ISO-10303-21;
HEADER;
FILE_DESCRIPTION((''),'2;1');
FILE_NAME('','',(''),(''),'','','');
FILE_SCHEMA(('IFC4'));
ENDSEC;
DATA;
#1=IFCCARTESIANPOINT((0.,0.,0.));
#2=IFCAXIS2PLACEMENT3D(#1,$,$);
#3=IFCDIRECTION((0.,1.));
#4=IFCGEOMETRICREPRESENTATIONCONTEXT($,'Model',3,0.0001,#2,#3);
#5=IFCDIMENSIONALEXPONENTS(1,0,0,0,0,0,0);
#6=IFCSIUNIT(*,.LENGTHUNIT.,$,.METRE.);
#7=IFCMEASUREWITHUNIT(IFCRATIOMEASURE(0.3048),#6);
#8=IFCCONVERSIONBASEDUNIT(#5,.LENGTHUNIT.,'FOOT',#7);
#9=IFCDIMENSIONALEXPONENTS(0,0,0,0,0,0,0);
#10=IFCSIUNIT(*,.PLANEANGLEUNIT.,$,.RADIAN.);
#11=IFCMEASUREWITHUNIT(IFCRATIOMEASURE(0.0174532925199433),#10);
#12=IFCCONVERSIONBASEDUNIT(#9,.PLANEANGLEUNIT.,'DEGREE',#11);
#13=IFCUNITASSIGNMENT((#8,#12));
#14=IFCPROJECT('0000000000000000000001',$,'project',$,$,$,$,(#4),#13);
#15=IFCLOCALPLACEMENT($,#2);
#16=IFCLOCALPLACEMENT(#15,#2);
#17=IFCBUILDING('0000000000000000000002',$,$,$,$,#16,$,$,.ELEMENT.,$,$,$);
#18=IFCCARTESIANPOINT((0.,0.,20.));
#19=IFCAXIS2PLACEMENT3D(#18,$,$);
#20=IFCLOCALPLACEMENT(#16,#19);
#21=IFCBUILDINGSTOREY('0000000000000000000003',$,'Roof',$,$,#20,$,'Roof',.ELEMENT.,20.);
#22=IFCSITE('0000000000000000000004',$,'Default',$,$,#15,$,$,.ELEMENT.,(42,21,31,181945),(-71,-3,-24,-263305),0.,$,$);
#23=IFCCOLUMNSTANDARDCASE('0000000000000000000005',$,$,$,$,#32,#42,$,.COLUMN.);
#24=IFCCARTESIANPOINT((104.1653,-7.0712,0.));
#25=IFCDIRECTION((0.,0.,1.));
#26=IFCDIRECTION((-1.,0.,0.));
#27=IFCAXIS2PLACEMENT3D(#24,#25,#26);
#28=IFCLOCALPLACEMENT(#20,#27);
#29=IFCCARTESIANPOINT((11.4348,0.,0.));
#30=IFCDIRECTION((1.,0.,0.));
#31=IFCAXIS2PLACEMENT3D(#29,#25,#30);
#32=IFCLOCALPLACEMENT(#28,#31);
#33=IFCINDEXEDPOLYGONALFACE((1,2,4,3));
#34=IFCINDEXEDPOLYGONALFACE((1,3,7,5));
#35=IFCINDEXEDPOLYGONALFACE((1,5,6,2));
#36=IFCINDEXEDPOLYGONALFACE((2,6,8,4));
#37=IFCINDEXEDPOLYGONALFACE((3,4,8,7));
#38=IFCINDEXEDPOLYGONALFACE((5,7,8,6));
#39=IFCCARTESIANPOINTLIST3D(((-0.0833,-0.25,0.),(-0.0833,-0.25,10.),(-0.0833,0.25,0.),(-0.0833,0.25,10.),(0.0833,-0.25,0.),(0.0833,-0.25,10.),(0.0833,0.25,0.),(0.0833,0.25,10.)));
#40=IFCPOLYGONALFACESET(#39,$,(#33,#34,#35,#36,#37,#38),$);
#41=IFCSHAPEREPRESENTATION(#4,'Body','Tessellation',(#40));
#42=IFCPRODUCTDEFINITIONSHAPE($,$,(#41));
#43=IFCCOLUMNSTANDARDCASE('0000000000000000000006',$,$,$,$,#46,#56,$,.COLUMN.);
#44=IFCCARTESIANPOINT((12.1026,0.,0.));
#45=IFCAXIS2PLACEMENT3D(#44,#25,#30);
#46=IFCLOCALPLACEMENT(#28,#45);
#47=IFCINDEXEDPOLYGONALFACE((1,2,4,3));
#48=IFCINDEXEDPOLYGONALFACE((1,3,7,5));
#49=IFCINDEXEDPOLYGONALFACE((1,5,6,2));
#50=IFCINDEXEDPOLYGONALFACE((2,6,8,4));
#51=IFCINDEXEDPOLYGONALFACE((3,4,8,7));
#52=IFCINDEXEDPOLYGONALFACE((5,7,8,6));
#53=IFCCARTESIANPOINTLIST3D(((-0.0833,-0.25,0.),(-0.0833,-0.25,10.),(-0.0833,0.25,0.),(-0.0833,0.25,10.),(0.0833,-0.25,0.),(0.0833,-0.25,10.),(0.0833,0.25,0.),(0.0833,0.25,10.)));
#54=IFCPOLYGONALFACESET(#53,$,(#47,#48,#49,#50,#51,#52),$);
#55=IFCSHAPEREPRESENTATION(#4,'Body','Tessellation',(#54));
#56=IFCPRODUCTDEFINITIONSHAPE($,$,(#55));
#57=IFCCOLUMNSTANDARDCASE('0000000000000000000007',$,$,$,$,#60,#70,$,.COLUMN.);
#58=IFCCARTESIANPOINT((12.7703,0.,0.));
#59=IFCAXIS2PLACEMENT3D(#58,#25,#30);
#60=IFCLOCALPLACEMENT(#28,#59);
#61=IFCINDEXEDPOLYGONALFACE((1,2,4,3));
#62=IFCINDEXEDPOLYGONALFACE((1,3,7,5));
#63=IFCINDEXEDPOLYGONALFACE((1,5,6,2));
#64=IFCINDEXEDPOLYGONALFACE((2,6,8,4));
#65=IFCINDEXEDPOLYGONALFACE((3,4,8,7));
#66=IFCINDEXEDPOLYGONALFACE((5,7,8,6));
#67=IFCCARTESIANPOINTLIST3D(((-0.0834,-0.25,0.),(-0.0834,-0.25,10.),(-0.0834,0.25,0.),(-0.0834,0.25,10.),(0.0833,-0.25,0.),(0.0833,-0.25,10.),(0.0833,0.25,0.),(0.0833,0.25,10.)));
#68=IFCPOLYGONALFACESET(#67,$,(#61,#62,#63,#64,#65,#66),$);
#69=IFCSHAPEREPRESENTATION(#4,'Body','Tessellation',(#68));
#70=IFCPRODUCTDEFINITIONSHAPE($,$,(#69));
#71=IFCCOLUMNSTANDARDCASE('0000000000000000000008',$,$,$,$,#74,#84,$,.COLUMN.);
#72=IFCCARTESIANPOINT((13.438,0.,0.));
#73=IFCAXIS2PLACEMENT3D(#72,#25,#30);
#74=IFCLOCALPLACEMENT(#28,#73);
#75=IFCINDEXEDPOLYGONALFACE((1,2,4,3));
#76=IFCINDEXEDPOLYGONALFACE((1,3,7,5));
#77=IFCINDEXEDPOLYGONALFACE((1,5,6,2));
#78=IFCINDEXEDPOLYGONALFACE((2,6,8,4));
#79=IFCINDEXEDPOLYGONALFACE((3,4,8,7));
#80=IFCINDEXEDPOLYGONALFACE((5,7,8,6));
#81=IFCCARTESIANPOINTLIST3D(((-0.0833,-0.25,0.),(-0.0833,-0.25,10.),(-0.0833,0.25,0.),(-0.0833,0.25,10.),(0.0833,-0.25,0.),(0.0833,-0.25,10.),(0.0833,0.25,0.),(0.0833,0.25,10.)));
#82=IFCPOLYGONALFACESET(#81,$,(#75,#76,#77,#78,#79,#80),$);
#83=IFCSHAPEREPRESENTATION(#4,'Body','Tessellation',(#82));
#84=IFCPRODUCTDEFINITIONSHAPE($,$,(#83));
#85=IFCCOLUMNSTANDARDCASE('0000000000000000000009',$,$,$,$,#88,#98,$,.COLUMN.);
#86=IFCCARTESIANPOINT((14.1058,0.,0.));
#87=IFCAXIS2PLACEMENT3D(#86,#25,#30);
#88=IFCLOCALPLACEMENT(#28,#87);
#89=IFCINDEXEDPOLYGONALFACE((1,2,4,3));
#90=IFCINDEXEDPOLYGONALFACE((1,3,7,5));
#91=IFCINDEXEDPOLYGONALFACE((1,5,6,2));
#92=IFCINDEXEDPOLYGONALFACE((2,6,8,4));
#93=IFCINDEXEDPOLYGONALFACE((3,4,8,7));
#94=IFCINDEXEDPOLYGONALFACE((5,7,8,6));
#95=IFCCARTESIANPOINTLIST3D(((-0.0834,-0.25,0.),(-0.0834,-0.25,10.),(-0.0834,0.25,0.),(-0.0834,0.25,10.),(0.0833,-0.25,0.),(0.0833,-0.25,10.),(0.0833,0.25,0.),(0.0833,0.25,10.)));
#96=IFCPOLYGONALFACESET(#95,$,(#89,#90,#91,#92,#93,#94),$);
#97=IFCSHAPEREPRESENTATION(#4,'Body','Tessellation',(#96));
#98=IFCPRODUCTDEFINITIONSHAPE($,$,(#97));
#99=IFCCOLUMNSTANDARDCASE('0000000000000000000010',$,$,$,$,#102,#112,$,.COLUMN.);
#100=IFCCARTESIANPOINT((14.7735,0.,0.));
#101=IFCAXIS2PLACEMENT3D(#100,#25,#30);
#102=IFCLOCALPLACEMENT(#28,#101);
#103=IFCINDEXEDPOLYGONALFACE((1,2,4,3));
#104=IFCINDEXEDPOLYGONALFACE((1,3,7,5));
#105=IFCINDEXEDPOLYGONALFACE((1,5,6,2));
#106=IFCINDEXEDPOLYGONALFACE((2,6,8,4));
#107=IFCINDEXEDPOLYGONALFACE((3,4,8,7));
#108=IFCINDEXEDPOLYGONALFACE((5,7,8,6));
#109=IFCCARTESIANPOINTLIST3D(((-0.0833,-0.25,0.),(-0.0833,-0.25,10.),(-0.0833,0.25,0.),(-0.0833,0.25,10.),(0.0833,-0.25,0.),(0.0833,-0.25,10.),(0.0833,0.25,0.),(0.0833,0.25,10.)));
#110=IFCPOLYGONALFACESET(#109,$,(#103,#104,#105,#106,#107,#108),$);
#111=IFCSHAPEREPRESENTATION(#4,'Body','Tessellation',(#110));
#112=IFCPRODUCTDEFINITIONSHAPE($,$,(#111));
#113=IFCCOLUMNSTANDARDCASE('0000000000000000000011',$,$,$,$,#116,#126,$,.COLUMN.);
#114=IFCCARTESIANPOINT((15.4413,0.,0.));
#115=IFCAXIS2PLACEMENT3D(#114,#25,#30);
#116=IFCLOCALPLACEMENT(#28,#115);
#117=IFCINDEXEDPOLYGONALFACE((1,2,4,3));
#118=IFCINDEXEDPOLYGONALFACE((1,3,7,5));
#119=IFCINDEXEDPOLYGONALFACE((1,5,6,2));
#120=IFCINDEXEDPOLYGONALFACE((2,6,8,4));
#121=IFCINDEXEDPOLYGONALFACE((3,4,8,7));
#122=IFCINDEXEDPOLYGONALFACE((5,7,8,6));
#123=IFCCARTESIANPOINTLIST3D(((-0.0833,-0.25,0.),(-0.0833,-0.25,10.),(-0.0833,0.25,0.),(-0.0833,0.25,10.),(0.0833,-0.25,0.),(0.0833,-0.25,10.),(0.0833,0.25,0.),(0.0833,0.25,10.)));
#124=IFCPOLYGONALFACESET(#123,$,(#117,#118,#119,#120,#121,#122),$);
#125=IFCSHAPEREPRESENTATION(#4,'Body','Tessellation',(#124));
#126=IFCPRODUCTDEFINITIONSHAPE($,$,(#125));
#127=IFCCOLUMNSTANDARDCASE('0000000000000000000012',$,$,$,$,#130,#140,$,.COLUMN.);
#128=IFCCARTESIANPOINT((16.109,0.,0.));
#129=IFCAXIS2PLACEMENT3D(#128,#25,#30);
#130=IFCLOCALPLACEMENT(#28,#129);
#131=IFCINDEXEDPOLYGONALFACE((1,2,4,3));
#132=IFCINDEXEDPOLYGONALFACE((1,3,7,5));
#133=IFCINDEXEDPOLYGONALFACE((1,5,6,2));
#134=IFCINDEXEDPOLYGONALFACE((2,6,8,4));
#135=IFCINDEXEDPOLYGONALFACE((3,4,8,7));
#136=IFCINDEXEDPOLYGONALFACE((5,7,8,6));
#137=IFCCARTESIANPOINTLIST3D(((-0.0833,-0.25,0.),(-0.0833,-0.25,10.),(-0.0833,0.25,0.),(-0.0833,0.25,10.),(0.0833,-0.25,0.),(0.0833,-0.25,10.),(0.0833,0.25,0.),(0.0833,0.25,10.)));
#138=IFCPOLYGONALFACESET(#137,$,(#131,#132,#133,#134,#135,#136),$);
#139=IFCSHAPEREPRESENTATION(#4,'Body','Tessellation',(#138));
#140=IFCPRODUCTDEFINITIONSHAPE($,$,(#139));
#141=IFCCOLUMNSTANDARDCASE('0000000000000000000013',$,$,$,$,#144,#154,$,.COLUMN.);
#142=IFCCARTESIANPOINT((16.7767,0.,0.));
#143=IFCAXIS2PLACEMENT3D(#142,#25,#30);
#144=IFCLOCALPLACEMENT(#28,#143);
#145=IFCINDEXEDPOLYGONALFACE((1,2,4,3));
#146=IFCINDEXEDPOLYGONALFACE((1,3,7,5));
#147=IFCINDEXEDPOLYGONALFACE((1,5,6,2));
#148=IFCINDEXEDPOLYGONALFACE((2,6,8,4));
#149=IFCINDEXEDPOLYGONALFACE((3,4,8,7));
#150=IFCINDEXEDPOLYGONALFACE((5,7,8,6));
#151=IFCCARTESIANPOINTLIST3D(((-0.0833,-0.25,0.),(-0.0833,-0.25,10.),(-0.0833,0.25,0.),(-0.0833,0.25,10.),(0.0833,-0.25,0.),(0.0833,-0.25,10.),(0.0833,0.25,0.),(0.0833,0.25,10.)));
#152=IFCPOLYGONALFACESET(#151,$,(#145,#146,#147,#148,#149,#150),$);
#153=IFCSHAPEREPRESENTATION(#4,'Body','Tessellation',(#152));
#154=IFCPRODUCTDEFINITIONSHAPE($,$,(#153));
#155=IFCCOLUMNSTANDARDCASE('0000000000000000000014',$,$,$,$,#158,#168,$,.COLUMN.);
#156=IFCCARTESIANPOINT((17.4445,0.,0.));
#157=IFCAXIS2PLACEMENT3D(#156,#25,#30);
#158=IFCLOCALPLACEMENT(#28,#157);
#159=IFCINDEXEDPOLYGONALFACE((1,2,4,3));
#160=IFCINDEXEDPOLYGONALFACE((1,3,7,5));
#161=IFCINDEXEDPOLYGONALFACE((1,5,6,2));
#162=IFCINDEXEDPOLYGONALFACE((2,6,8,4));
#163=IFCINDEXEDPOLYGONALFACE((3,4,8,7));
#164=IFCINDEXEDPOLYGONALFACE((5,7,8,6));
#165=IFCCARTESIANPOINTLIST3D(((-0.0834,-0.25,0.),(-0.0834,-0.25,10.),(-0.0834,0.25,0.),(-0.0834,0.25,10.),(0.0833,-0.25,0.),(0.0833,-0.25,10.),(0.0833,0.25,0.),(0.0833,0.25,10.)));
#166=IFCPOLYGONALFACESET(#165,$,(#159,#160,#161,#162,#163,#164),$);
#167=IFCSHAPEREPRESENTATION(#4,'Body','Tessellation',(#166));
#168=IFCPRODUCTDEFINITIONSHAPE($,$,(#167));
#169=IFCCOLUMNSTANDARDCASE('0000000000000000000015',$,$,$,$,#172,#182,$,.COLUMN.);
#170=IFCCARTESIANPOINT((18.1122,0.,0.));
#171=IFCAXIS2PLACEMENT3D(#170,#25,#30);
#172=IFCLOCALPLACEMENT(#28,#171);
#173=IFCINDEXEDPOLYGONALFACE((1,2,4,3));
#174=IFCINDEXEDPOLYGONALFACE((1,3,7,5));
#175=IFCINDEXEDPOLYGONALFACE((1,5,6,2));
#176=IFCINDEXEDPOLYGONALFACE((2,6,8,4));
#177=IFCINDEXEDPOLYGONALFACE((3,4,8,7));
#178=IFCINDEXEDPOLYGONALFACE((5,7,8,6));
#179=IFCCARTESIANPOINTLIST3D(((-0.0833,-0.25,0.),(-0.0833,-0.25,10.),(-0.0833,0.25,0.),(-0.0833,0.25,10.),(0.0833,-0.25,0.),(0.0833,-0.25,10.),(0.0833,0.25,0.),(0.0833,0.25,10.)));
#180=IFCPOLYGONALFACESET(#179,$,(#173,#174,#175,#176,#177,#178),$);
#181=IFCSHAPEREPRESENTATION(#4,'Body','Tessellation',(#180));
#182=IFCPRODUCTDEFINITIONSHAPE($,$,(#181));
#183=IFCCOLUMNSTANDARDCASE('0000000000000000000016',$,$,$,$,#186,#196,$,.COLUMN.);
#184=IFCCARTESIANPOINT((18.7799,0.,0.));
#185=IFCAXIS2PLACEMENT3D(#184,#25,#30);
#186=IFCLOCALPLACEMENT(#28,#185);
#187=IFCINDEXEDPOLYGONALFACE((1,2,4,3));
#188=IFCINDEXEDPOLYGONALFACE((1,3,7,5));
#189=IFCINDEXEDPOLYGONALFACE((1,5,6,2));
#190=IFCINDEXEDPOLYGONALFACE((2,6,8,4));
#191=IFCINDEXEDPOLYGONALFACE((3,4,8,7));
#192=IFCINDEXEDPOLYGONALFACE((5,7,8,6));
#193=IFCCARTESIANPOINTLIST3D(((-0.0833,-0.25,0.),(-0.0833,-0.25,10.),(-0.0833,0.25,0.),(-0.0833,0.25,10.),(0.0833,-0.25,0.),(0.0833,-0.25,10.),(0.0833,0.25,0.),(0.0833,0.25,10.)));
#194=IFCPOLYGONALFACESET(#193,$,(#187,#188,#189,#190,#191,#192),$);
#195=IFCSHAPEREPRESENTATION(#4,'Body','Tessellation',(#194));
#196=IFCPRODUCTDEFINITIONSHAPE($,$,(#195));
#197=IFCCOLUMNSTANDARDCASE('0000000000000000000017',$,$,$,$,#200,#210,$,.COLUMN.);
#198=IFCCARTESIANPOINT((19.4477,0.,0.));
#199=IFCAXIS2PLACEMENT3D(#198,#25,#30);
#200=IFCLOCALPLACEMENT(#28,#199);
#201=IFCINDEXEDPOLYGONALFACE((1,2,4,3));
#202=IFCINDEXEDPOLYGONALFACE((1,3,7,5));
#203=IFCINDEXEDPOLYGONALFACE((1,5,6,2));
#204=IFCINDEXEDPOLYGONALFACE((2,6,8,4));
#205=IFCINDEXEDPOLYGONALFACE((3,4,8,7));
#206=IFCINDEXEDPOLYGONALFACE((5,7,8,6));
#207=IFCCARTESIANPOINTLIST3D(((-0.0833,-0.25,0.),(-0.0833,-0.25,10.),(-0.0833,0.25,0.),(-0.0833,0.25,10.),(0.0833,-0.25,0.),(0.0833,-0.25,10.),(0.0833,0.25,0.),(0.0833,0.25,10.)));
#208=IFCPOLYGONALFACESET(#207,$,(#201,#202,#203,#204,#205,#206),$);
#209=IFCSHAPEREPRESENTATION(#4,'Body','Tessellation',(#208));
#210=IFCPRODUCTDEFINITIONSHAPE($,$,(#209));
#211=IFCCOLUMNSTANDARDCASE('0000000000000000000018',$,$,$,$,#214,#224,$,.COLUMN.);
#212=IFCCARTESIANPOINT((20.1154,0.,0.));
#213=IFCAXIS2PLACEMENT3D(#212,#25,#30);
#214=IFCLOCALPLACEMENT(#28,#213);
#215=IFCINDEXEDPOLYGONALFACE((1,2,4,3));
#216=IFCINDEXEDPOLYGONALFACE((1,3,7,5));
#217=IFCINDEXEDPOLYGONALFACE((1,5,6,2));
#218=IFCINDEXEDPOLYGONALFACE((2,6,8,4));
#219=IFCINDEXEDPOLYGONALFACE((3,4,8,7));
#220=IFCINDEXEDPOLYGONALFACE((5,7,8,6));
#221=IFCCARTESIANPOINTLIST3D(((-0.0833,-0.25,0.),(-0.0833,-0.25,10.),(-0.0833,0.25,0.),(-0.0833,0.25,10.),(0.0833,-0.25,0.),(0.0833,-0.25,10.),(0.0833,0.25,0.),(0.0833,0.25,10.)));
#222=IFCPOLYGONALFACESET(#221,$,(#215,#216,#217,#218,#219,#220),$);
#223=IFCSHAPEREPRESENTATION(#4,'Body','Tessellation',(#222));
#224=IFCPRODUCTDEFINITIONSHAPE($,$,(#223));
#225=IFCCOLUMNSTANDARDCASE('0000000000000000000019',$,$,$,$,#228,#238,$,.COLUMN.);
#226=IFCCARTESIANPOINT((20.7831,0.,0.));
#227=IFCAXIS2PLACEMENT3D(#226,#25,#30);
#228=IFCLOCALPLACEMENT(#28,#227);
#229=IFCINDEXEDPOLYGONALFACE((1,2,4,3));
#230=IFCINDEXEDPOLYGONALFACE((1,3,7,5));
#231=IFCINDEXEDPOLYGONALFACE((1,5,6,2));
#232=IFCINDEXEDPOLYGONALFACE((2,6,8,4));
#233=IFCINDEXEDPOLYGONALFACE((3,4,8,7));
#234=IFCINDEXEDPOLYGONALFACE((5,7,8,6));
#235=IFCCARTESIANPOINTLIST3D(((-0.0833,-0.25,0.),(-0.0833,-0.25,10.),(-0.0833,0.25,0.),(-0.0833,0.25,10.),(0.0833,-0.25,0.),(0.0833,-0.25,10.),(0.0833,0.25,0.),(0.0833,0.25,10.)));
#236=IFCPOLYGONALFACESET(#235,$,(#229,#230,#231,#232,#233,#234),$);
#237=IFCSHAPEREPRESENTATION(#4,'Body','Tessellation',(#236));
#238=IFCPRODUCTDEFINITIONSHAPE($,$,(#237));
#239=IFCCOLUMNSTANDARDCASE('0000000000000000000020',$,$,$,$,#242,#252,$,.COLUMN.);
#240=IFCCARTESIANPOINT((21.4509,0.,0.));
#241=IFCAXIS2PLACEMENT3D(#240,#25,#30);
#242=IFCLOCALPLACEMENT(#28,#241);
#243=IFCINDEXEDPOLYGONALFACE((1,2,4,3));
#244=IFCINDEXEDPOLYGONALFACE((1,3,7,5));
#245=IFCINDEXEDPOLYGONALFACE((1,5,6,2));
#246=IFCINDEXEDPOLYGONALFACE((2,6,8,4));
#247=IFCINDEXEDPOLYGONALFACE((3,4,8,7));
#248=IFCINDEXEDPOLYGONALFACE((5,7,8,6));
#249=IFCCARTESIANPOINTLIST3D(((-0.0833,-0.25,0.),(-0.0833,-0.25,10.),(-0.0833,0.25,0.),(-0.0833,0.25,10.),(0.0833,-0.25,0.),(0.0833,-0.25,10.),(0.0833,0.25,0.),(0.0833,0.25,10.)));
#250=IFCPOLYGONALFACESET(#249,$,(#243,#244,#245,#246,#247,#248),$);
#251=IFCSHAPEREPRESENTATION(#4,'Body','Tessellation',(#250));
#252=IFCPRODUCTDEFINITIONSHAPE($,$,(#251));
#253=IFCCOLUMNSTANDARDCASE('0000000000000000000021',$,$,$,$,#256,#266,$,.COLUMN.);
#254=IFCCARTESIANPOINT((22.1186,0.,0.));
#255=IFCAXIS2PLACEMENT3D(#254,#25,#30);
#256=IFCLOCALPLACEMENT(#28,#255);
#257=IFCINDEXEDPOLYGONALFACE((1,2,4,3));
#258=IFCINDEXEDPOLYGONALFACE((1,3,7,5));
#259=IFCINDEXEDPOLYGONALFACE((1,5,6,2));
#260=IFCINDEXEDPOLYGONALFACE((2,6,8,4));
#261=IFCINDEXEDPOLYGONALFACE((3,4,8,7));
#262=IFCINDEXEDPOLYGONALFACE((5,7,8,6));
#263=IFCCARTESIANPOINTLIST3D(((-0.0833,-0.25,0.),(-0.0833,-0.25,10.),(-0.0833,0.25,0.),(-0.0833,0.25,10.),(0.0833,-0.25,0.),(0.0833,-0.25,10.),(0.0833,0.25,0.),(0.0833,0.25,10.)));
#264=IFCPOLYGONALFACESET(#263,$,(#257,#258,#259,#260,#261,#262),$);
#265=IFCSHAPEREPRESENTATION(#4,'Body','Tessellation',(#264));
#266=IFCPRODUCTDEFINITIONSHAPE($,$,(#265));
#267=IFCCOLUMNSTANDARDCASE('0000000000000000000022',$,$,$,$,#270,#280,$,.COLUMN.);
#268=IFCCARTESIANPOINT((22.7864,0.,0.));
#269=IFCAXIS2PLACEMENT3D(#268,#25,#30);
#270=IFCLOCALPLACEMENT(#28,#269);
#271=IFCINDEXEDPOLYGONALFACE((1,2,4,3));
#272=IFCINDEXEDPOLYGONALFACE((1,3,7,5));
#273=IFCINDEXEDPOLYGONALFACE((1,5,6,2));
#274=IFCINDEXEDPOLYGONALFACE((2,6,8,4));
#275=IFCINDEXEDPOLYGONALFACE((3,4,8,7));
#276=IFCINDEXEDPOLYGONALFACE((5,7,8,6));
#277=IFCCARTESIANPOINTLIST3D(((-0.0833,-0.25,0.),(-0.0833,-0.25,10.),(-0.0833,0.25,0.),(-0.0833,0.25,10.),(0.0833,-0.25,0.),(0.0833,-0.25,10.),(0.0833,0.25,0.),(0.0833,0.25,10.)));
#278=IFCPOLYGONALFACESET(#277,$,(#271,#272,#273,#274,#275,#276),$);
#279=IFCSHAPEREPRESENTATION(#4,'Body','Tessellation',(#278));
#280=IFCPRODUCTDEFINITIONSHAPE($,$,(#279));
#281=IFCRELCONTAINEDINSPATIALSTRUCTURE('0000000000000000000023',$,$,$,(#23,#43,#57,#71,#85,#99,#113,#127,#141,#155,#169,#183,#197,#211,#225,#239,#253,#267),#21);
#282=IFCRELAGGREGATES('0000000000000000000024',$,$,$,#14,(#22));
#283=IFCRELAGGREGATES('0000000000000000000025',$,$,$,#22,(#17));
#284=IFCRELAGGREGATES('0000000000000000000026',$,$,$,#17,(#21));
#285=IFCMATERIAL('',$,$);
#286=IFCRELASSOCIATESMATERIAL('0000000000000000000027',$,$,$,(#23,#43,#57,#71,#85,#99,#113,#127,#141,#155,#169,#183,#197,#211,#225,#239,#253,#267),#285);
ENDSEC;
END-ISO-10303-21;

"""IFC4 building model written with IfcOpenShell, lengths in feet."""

from ifc_helpers import new_model, entity, si_unit, converted_unit, direction, frame, origin, place, context, project, spatial, rectangle, extrude, material, element, save


model = new_model("IFC4")

# Units and contexts
model_context = context("Model", 3, precision=0.0001, world=origin(), true_north=direction((0.0, 1.0)))
ifc_project = project(units=[converted_unit("LENGTHUNIT", "FOOT", entity("IfcRatioMeasure", 0.3048), si_unit("LENGTHUNIT", "METRE"), dimensions=[1, 0, 0, 0, 0, 0, 0]), converted_unit("PLANEANGLEUNIT", "DEGREE", entity("IfcRatioMeasure", 0.0174532925199433), si_unit("PLANEANGLEUNIT", "RADIAN"), dimensions=[0, 0, 0, 0, 0, 0, 0])], contexts=[model_context])

# Site, building, storey
site_placement = place(None, origin())
site = spatial("IfcSite", under=ifc_project, at=site_placement, Name="Default", CompositionType="ELEMENT", RefLatitude=(42, 21, 31, 181945), RefLongitude=(-71, -3, -24, -263305), RefElevation=0.0)
building_placement = place(site_placement, origin())
building = spatial("IfcBuilding", under=site, at=building_placement, CompositionType="ELEMENT")
storey_placement = place(building_placement, frame((0.0, 0.0, 20.0)))
storey = spatial("IfcBuildingStorey", under=building, at=storey_placement, Name="Roof", LongName="Roof", CompositionType="ELEMENT", Elevation=20.0)

# Columns
ifc_material_1 = material(Name="")
placement_1 = place(storey_placement, frame((104.1653, -7.0712, 0.0), z_axis=(0.0, 0.0, 1.0), x_axis=(-1.0, 0.0, 0.0)))
for number, where, z_axis, x_axis in (
    (1, (11.4348, 0.0, 0.0), (0.0, 0.0, 1.0), (1.0, 0.0, 0.0)),
    (2, (12.1026, 0.0, 0.0), (0.0, 0.0, 1.0), (1.0, 0.0, 0.0)),
    (3, (12.7703, 0.0, 0.0), (0.0, 0.0, 1.0), (1.0, 0.0, 0.0)),
    (4, (13.438, 0.0, 0.0), (0.0, 0.0, 1.0), (1.0, 0.0, 0.0)),
    (5, (14.1058, 0.0, 0.0), (0.0, 0.0, 1.0), (1.0, 0.0, 0.0)),
    (6, (14.7735, 0.0, 0.0), (0.0, 0.0, 1.0), (1.0, 0.0, 0.0)),
    (7, (15.4413, 0.0, 0.0), (0.0, 0.0, 1.0), (1.0, 0.0, 0.0)),
    (8, (16.109, 0.0, 0.0), (0.0, 0.0, 1.0), (1.0, 0.0, 0.0)),
    (9, (16.7767, 0.0, 0.0), (0.0, 0.0, 1.0), (1.0, 0.0, 0.0)),
    (10, (17.4445, 0.0, 0.0), (0.0, 0.0, 1.0), (1.0, 0.0, 0.0)),
    (11, (18.1122, 0.0, 0.0), (0.0, 0.0, 1.0), (1.0, 0.0, 0.0)),
    (12, (18.7799, 0.0, 0.0), (0.0, 0.0, 1.0), (1.0, 0.0, 0.0)),
    (13, (19.4477, 0.0, 0.0), (0.0, 0.0, 1.0), (1.0, 0.0, 0.0)),
    (14, (20.1154, 0.0, 0.0), (0.0, 0.0, 1.0), (1.0, 0.0, 0.0)),
    (15, (20.7831, 0.0, 0.0), (0.0, 0.0, 1.0), (1.0, 0.0, 0.0)),
    (16, (21.4509, 0.0, 0.0), (0.0, 0.0, 1.0), (1.0, 0.0, 0.0)),
    (17, (22.1186, 0.0, 0.0), (0.0, 0.0, 1.0), (1.0, 0.0, 0.0)),
    (18, (22.7864, 0.0, 0.0), (0.0, 0.0, 1.0), (1.0, 0.0, 0.0)),
):
    element("IfcColumnStandardCase", number, at=place(placement_1, frame(where, z_axis=z_axis, x_axis=x_axis)), inside=storey, material=ifc_material_1, PredefinedType="COLUMN", context=model_context, shape_type="SweptSolid", body=[
        extrude(rectangle(XDim=0.1667, YDim=0.5), origin(), (0.0, 0.0, 1.0), 10.0),
    ])

save(model, "model.ifc")
